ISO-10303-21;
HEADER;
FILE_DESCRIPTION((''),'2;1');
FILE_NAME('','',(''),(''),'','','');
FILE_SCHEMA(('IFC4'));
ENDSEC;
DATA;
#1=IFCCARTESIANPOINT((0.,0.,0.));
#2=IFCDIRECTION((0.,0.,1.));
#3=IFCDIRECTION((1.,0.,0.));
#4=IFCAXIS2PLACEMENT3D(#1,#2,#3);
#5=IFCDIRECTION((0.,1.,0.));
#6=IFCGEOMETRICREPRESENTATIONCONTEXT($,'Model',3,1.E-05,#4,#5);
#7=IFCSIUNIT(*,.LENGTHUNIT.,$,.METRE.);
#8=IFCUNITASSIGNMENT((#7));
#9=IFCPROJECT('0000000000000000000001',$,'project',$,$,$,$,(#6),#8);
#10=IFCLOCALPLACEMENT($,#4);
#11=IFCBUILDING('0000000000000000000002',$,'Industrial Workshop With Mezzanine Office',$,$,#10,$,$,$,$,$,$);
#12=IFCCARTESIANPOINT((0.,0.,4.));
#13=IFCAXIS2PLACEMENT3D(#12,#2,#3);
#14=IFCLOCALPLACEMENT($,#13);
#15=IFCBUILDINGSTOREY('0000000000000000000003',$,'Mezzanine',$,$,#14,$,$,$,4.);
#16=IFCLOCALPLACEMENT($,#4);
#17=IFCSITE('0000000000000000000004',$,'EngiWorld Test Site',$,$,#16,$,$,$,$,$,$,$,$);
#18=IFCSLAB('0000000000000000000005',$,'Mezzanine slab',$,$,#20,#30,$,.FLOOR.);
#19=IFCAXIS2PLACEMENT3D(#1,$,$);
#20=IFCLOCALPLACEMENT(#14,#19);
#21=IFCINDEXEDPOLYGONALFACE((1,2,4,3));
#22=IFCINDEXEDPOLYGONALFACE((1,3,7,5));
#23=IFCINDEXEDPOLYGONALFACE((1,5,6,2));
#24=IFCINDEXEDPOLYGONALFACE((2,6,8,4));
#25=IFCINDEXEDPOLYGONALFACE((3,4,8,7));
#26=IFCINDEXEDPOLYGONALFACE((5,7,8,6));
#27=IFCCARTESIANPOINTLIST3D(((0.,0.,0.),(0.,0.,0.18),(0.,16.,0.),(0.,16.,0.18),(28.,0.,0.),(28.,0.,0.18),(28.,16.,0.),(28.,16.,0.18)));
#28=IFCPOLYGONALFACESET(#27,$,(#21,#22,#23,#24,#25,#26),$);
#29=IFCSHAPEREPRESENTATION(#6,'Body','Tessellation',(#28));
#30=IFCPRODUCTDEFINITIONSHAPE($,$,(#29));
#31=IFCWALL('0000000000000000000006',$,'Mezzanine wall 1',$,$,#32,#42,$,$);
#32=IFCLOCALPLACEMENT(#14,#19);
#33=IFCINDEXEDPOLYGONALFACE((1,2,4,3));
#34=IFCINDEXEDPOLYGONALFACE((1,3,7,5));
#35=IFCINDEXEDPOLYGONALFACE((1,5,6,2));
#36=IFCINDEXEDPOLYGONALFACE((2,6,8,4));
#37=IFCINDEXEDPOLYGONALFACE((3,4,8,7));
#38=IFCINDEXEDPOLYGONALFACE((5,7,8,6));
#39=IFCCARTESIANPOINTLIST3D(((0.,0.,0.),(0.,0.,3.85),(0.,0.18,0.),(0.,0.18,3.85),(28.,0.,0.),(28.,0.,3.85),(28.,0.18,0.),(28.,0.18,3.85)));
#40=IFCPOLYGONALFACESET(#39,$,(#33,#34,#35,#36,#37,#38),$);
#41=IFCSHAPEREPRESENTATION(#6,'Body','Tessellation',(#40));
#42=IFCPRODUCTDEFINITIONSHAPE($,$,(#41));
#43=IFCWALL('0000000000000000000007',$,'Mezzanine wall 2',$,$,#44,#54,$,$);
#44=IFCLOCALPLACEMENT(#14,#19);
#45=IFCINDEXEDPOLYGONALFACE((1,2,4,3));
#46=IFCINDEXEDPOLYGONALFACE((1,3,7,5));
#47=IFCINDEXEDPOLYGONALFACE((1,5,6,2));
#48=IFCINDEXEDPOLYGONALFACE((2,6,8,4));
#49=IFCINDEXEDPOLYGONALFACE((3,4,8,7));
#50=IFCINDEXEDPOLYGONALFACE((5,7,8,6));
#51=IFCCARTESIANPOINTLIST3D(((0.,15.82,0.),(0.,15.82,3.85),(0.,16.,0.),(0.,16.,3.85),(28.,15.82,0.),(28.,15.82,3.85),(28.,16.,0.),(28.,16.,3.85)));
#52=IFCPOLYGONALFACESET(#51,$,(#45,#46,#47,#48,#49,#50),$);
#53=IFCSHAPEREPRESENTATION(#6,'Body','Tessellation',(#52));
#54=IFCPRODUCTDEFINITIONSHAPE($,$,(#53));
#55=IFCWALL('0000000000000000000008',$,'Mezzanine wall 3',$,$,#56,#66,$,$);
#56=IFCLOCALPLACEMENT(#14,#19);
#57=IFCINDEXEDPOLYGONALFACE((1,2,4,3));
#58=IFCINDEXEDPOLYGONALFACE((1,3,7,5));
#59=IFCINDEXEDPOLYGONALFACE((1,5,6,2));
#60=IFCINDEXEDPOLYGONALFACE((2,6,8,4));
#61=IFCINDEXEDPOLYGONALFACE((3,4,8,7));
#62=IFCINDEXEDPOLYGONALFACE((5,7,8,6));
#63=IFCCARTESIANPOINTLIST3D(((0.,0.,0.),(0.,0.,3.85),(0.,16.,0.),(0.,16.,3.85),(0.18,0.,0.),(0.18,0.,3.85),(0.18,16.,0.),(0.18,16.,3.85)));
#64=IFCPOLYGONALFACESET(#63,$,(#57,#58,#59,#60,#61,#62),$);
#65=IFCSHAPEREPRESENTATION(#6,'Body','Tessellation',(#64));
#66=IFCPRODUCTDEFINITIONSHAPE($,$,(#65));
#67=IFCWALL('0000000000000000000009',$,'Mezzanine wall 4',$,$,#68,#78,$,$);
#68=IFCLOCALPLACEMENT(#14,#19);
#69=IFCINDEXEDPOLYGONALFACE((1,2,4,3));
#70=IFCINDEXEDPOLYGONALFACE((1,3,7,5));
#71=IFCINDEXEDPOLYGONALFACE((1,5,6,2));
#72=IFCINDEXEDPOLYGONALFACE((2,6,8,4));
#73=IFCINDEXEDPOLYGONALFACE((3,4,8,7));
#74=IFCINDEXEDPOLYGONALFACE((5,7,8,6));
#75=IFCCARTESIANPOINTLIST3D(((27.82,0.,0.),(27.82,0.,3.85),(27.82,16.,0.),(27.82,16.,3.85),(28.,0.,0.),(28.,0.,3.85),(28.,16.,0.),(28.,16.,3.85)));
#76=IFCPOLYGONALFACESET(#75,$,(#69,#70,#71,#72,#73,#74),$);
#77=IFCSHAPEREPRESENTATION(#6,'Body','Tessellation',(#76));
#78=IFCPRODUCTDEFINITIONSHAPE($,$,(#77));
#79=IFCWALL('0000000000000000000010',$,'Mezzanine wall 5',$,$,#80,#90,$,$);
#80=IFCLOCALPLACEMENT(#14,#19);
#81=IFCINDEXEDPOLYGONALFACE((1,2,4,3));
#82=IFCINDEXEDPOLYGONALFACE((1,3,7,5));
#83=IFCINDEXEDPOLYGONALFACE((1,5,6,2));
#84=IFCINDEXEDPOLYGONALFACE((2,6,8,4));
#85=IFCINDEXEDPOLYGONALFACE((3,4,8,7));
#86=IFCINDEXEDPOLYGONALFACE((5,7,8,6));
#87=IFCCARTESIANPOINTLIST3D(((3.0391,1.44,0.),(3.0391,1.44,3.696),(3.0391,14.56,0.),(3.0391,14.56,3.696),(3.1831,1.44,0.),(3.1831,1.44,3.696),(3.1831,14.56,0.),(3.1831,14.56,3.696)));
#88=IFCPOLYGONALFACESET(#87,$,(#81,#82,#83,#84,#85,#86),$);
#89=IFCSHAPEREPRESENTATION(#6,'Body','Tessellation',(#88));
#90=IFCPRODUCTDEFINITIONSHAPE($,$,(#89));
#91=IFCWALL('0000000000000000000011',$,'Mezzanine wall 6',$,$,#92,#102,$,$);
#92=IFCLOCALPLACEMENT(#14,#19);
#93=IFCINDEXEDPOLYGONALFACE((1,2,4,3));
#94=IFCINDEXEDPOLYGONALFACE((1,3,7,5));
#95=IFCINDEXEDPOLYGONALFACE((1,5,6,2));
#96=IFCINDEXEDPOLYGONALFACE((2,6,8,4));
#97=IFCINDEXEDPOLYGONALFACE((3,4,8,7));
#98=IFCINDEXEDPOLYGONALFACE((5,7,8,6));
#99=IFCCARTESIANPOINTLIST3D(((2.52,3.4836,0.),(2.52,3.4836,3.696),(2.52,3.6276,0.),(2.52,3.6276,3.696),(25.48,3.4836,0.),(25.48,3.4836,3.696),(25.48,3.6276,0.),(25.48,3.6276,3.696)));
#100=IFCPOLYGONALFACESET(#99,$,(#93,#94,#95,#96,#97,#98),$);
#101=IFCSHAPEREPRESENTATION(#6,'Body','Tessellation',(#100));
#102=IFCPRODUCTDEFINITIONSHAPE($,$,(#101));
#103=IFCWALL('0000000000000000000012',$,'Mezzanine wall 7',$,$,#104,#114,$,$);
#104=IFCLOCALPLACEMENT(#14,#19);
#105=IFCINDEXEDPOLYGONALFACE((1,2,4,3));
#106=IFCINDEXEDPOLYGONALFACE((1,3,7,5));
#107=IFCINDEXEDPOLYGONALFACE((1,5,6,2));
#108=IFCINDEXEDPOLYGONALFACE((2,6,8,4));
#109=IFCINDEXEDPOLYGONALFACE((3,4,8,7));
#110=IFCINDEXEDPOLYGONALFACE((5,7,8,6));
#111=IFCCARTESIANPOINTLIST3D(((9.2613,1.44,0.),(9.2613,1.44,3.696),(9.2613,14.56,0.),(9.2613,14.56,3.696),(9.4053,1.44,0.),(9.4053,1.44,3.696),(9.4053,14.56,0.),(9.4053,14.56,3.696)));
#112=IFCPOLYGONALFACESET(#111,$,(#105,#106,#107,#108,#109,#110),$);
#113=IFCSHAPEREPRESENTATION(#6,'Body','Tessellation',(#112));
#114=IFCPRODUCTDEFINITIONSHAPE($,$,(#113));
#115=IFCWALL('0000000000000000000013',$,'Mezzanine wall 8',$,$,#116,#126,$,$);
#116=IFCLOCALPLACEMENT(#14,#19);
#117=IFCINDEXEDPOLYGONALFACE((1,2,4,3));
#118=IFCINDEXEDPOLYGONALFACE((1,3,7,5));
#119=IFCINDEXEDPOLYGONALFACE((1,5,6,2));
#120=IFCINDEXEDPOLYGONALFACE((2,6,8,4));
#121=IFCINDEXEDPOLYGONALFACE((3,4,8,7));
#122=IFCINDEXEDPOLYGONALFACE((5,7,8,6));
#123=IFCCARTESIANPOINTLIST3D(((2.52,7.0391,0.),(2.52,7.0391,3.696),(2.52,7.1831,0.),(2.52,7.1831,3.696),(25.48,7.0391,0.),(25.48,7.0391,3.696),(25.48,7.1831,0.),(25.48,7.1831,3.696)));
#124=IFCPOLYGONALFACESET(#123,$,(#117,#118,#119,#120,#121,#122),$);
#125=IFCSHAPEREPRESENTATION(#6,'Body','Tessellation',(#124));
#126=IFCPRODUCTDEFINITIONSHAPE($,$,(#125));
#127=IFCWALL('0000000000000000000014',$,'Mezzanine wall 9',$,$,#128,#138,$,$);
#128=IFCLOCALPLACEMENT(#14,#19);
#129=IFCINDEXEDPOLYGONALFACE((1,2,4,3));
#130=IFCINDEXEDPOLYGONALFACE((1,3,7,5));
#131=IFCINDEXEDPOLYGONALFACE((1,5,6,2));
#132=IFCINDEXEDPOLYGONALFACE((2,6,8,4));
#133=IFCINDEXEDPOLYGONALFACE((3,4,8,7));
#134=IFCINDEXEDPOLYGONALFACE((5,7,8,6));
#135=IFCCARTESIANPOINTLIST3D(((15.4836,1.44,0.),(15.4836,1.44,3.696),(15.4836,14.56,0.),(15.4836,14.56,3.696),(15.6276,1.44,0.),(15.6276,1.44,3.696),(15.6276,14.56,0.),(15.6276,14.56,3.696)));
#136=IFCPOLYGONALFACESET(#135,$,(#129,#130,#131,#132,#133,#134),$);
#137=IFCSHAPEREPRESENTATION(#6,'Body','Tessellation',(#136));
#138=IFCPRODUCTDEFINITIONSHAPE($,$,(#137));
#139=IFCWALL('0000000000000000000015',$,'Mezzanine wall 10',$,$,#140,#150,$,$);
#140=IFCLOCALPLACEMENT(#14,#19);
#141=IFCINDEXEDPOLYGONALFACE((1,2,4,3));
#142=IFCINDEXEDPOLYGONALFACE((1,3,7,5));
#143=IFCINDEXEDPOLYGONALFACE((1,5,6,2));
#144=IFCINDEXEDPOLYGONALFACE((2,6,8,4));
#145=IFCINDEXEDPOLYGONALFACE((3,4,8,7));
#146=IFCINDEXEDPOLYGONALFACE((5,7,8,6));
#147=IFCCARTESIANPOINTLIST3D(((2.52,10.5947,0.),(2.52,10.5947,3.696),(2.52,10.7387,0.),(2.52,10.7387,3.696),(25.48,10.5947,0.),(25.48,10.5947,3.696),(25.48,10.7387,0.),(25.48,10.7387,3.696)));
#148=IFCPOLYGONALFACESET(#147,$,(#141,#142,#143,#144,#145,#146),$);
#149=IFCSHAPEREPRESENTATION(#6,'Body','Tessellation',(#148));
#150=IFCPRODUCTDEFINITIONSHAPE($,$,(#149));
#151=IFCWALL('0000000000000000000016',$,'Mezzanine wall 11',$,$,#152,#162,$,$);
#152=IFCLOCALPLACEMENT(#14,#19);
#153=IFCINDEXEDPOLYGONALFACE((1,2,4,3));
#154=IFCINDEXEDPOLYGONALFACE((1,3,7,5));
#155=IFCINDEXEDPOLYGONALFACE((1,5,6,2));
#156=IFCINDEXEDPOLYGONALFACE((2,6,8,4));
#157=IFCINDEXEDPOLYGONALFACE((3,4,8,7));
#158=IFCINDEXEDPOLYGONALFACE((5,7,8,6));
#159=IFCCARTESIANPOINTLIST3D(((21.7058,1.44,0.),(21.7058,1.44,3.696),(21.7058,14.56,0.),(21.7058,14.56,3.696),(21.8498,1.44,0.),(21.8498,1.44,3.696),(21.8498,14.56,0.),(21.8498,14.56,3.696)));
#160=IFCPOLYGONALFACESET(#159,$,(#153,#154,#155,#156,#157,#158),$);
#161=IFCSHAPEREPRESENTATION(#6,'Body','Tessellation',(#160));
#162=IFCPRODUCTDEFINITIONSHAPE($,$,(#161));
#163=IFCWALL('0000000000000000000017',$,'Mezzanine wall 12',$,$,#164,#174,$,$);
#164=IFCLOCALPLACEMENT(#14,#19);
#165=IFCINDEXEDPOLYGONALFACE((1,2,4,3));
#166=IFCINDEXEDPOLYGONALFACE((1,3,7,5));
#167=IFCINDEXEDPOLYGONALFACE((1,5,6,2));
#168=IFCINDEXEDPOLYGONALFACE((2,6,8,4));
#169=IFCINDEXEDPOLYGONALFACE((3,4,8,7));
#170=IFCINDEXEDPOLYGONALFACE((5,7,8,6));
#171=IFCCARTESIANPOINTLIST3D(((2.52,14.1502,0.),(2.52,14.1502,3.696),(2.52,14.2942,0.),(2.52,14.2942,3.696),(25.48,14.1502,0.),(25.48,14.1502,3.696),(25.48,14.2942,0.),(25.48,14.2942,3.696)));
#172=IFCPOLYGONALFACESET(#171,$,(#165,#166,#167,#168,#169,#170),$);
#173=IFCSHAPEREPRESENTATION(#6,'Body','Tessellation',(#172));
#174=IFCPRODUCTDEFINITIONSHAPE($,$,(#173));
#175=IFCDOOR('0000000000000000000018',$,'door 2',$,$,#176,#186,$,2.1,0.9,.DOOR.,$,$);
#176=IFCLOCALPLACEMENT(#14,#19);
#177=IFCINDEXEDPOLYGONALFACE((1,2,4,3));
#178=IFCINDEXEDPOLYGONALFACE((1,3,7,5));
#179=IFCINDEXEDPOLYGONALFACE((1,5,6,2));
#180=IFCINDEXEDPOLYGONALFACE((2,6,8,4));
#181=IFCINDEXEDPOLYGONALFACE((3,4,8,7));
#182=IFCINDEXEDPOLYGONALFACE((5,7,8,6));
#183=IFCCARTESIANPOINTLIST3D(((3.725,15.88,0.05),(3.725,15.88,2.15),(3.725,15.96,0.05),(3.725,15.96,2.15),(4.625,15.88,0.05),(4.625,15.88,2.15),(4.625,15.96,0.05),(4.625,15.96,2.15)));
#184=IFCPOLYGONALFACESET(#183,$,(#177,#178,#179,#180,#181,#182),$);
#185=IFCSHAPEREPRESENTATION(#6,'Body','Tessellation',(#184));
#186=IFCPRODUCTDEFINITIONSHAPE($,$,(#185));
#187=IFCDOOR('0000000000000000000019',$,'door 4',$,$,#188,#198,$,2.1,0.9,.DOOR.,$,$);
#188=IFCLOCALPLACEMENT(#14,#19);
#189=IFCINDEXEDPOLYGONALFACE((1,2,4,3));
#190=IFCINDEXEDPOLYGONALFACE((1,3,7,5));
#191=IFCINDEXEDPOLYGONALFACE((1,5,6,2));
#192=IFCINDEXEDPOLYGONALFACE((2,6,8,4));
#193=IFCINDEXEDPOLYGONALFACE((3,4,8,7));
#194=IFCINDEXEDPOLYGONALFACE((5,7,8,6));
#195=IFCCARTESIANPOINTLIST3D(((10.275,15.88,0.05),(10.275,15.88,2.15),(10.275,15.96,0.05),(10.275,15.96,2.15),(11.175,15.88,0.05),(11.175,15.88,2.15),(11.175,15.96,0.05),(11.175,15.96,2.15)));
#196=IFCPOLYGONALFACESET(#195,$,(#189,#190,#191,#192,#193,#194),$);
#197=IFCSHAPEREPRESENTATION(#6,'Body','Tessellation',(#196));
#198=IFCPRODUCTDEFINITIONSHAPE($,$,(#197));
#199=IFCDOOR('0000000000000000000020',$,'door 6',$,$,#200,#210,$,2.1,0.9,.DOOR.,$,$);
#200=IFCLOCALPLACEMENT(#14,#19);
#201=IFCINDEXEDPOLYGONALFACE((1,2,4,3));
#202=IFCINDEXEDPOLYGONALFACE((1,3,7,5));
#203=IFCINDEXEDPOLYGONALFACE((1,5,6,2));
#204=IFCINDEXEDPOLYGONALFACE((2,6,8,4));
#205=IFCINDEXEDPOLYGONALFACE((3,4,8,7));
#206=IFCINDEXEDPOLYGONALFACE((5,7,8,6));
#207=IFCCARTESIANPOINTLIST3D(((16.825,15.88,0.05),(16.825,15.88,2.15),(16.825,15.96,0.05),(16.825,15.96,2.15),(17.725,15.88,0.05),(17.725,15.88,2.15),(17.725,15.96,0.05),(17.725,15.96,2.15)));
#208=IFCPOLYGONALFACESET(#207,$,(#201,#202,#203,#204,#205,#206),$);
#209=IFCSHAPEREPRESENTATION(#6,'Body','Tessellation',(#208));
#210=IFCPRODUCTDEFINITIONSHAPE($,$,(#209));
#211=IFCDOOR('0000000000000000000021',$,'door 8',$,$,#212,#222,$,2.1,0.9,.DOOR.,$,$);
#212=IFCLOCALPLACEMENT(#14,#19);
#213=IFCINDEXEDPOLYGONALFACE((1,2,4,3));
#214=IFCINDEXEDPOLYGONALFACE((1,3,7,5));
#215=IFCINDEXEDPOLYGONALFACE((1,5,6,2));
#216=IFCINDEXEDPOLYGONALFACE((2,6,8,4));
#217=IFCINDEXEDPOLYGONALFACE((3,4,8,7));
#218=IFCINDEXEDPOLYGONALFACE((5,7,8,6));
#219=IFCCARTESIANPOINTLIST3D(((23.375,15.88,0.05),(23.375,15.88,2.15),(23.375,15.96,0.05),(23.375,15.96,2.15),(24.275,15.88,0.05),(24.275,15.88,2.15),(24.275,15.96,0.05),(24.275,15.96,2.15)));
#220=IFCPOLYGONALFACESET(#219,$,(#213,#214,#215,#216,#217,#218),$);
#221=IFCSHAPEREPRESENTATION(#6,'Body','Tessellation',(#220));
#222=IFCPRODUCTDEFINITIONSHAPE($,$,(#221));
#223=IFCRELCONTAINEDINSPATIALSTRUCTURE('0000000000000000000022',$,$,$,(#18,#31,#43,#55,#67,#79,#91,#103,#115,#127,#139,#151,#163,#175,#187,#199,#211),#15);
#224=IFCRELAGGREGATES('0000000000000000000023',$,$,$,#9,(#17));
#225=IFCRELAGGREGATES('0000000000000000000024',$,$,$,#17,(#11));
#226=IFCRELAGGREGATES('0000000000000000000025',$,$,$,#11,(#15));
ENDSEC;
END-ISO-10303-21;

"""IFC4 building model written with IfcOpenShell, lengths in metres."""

from ifc_helpers import new_model, si_unit, direction, frame, origin_with_axes, origin_2d_with_axis, place, context, project, spatial, rectangle, extrude, element, save


model = new_model("IFC4")

# Units and contexts
model_context = context("Model", 3, precision=1e-05, world=origin_with_axes(), true_north=direction((0.0, 1.0, 0.0)))
ifc_project = project(units=[si_unit("LENGTHUNIT", "METRE")], contexts=[model_context])

# Site, building, storey
site_placement = place(None, origin_with_axes())
site = spatial("IfcSite", under=ifc_project, at=site_placement, Name="EngiWorld Test Site")
building_placement = place(None, origin_with_axes())
building = spatial("IfcBuilding", under=site, at=building_placement, Name="Industrial Workshop With Mezzanine Office")
storey_placement = place(None, frame((0.0, 0.0, 4.0), z_axis=(0.0, 0.0, 1.0), x_axis=(1.0, 0.0, 0.0)))
storey = spatial("IfcBuildingStorey", under=building, at=storey_placement, Name="Mezzanine", Elevation=4.0)

# Slab
slab_placement = place(None, frame((14.0, 8.0, 4.0), z_axis=(0.0, 0.0, 1.0), x_axis=(1.0, 0.0, 0.0)))
element("IfcSlab", 1, at=slab_placement, inside=storey, Name="Mezzanine slab", PredefinedType="FLOOR", context=model_context, shape_type="SweptSolid", body=[
    extrude(rectangle(XDim=28.0, YDim=16.0, at=origin_2d_with_axis()), origin_with_axes(), (0.0, 0.0, 1.0), 0.18),
])

# Walls
for number, where, z_axis, x_axis, name in (
    (2, (14.0, 0.09, 4.0), (0.0, 0.0, 1.0), (1.0, 0.0, 0.0), "Mezzanine wall 1"),
    (3, (14.0, 15.91, 4.0), (0.0, 0.0, 1.0), (1.0, 0.0, 0.0), "Mezzanine wall 2"),
):
    element("IfcWall", number, at=place(None, frame(where, z_axis=z_axis, x_axis=x_axis)), inside=storey, Name=name, context=model_context, shape_type="SweptSolid", body=[
        extrude(rectangle(XDim=28.0, YDim=0.18, at=origin_2d_with_axis()), origin_with_axes(), (0.0, 0.0, 1.0), 3.85),
    ])
for number, where, z_axis, x_axis, name in (
    (4, (0.09, 8.0, 4.0), (0.0, 0.0, 1.0), (1.0, 0.0, 0.0), "Mezzanine wall 3"),
    (5, (27.91, 8.0, 4.0), (0.0, 0.0, 1.0), (1.0, 0.0, 0.0), "Mezzanine wall 4"),
):
    element("IfcWall", number, at=place(None, frame(where, z_axis=z_axis, x_axis=x_axis)), inside=storey, Name=name, context=model_context, shape_type="SweptSolid", body=[
        extrude(rectangle(XDim=0.18, YDim=16.0, at=origin_2d_with_axis()), origin_with_axes(), (0.0, 0.0, 1.0), 3.85),
    ])
wall_1_placement = place(None, frame((3.1111, 8.0, 4.0), z_axis=(0.0, 0.0, 1.0), x_axis=(1.0, 0.0, 0.0)))
element("IfcWall", 6, at=wall_1_placement, inside=storey, Name="Mezzanine wall 5", context=model_context, shape_type="SweptSolid", body=[
    extrude(rectangle(XDim=0.144, YDim=13.12, at=origin_2d_with_axis()), origin_with_axes(), (0.0, 0.0, 1.0), 3.696),
])
wall_2_placement = place(None, frame((14.0, 3.5556, 4.0), z_axis=(0.0, 0.0, 1.0), x_axis=(1.0, 0.0, 0.0)))
element("IfcWall", 7, at=wall_2_placement, inside=storey, Name="Mezzanine wall 6", context=model_context, shape_type="SweptSolid", body=[
    extrude(rectangle(XDim=22.96, YDim=0.144, at=origin_2d_with_axis()), origin_with_axes(), (0.0, 0.0, 1.0), 3.696),
])
wall_3_placement = place(None, frame((9.3333, 8.0, 4.0), z_axis=(0.0, 0.0, 1.0), x_axis=(1.0, 0.0, 0.0)))
element("IfcWall", 8, at=wall_3_placement, inside=storey, Name="Mezzanine wall 7", context=model_context, shape_type="SweptSolid", body=[
    extrude(rectangle(XDim=0.144, YDim=13.12, at=origin_2d_with_axis()), origin_with_axes(), (0.0, 0.0, 1.0), 3.696),
])
wall_4_placement = place(None, frame((14.0, 7.1111, 4.0), z_axis=(0.0, 0.0, 1.0), x_axis=(1.0, 0.0, 0.0)))
element("IfcWall", 9, at=wall_4_placement, inside=storey, Name="Mezzanine wall 8", context=model_context, shape_type="SweptSolid", body=[
    extrude(rectangle(XDim=22.96, YDim=0.144, at=origin_2d_with_axis()), origin_with_axes(), (0.0, 0.0, 1.0), 3.696),
])
wall_5_placement = place(None, frame((15.5556, 8.0, 4.0), z_axis=(0.0, 0.0, 1.0), x_axis=(1.0, 0.0, 0.0)))
element("IfcWall", 10, at=wall_5_placement, inside=storey, Name="Mezzanine wall 9", context=model_context, shape_type="SweptSolid", body=[
    extrude(rectangle(XDim=0.144, YDim=13.12, at=origin_2d_with_axis()), origin_with_axes(), (0.0, 0.0, 1.0), 3.696),
])
wall_6_placement = place(None, frame((14.0, 10.6667, 4.0), z_axis=(0.0, 0.0, 1.0), x_axis=(1.0, 0.0, 0.0)))
element("IfcWall", 11, at=wall_6_placement, inside=storey, Name="Mezzanine wall 10", context=model_context, shape_type="SweptSolid", body=[
    extrude(rectangle(XDim=22.96, YDim=0.144, at=origin_2d_with_axis()), origin_with_axes(), (0.0, 0.0, 1.0), 3.696),
])
wall_7_placement = place(None, frame((21.7778, 8.0, 4.0), z_axis=(0.0, 0.0, 1.0), x_axis=(1.0, 0.0, 0.0)))
element("IfcWall", 12, at=wall_7_placement, inside=storey, Name="Mezzanine wall 11", context=model_context, shape_type="SweptSolid", body=[
    extrude(rectangle(XDim=0.144, YDim=13.12, at=origin_2d_with_axis()), origin_with_axes(), (0.0, 0.0, 1.0), 3.696),
])
wall_8_placement = place(None, frame((14.0, 14.2222, 4.0), z_axis=(0.0, 0.0, 1.0), x_axis=(1.0, 0.0, 0.0)))
element("IfcWall", 13, at=wall_8_placement, inside=storey, Name="Mezzanine wall 12", context=model_context, shape_type="SweptSolid", body=[
    extrude(rectangle(XDim=22.96, YDim=0.144, at=origin_2d_with_axis()), origin_with_axes(), (0.0, 0.0, 1.0), 3.696),
])

# Doors
for number, where, z_axis, x_axis, name in (
    (14, (4.175, 15.92, 4.05), (0.0, 0.0, 1.0), (1.0, 0.0, 0.0), "door 2"),
    (15, (10.725, 15.92, 4.05), (0.0, 0.0, 1.0), (1.0, 0.0, 0.0), "door 4"),
    (16, (17.275, 15.92, 4.05), (0.0, 0.0, 1.0), (1.0, 0.0, 0.0), "door 6"),
    (17, (23.825, 15.92, 4.05), (0.0, 0.0, 1.0), (1.0, 0.0, 0.0), "door 8"),
):
    element("IfcDoor", number, at=place(None, frame(where, z_axis=z_axis, x_axis=x_axis)), inside=storey, Name=name, OverallHeight=2.1, OverallWidth=0.9, PredefinedType="DOOR", context=model_context, shape_type="SweptSolid", body=[
        extrude(rectangle(XDim=0.9, YDim=0.08, at=origin_2d_with_axis()), origin_with_axes(), (0.0, 0.0, 1.0), 2.1),
    ])

save(model, "model.ifc")
